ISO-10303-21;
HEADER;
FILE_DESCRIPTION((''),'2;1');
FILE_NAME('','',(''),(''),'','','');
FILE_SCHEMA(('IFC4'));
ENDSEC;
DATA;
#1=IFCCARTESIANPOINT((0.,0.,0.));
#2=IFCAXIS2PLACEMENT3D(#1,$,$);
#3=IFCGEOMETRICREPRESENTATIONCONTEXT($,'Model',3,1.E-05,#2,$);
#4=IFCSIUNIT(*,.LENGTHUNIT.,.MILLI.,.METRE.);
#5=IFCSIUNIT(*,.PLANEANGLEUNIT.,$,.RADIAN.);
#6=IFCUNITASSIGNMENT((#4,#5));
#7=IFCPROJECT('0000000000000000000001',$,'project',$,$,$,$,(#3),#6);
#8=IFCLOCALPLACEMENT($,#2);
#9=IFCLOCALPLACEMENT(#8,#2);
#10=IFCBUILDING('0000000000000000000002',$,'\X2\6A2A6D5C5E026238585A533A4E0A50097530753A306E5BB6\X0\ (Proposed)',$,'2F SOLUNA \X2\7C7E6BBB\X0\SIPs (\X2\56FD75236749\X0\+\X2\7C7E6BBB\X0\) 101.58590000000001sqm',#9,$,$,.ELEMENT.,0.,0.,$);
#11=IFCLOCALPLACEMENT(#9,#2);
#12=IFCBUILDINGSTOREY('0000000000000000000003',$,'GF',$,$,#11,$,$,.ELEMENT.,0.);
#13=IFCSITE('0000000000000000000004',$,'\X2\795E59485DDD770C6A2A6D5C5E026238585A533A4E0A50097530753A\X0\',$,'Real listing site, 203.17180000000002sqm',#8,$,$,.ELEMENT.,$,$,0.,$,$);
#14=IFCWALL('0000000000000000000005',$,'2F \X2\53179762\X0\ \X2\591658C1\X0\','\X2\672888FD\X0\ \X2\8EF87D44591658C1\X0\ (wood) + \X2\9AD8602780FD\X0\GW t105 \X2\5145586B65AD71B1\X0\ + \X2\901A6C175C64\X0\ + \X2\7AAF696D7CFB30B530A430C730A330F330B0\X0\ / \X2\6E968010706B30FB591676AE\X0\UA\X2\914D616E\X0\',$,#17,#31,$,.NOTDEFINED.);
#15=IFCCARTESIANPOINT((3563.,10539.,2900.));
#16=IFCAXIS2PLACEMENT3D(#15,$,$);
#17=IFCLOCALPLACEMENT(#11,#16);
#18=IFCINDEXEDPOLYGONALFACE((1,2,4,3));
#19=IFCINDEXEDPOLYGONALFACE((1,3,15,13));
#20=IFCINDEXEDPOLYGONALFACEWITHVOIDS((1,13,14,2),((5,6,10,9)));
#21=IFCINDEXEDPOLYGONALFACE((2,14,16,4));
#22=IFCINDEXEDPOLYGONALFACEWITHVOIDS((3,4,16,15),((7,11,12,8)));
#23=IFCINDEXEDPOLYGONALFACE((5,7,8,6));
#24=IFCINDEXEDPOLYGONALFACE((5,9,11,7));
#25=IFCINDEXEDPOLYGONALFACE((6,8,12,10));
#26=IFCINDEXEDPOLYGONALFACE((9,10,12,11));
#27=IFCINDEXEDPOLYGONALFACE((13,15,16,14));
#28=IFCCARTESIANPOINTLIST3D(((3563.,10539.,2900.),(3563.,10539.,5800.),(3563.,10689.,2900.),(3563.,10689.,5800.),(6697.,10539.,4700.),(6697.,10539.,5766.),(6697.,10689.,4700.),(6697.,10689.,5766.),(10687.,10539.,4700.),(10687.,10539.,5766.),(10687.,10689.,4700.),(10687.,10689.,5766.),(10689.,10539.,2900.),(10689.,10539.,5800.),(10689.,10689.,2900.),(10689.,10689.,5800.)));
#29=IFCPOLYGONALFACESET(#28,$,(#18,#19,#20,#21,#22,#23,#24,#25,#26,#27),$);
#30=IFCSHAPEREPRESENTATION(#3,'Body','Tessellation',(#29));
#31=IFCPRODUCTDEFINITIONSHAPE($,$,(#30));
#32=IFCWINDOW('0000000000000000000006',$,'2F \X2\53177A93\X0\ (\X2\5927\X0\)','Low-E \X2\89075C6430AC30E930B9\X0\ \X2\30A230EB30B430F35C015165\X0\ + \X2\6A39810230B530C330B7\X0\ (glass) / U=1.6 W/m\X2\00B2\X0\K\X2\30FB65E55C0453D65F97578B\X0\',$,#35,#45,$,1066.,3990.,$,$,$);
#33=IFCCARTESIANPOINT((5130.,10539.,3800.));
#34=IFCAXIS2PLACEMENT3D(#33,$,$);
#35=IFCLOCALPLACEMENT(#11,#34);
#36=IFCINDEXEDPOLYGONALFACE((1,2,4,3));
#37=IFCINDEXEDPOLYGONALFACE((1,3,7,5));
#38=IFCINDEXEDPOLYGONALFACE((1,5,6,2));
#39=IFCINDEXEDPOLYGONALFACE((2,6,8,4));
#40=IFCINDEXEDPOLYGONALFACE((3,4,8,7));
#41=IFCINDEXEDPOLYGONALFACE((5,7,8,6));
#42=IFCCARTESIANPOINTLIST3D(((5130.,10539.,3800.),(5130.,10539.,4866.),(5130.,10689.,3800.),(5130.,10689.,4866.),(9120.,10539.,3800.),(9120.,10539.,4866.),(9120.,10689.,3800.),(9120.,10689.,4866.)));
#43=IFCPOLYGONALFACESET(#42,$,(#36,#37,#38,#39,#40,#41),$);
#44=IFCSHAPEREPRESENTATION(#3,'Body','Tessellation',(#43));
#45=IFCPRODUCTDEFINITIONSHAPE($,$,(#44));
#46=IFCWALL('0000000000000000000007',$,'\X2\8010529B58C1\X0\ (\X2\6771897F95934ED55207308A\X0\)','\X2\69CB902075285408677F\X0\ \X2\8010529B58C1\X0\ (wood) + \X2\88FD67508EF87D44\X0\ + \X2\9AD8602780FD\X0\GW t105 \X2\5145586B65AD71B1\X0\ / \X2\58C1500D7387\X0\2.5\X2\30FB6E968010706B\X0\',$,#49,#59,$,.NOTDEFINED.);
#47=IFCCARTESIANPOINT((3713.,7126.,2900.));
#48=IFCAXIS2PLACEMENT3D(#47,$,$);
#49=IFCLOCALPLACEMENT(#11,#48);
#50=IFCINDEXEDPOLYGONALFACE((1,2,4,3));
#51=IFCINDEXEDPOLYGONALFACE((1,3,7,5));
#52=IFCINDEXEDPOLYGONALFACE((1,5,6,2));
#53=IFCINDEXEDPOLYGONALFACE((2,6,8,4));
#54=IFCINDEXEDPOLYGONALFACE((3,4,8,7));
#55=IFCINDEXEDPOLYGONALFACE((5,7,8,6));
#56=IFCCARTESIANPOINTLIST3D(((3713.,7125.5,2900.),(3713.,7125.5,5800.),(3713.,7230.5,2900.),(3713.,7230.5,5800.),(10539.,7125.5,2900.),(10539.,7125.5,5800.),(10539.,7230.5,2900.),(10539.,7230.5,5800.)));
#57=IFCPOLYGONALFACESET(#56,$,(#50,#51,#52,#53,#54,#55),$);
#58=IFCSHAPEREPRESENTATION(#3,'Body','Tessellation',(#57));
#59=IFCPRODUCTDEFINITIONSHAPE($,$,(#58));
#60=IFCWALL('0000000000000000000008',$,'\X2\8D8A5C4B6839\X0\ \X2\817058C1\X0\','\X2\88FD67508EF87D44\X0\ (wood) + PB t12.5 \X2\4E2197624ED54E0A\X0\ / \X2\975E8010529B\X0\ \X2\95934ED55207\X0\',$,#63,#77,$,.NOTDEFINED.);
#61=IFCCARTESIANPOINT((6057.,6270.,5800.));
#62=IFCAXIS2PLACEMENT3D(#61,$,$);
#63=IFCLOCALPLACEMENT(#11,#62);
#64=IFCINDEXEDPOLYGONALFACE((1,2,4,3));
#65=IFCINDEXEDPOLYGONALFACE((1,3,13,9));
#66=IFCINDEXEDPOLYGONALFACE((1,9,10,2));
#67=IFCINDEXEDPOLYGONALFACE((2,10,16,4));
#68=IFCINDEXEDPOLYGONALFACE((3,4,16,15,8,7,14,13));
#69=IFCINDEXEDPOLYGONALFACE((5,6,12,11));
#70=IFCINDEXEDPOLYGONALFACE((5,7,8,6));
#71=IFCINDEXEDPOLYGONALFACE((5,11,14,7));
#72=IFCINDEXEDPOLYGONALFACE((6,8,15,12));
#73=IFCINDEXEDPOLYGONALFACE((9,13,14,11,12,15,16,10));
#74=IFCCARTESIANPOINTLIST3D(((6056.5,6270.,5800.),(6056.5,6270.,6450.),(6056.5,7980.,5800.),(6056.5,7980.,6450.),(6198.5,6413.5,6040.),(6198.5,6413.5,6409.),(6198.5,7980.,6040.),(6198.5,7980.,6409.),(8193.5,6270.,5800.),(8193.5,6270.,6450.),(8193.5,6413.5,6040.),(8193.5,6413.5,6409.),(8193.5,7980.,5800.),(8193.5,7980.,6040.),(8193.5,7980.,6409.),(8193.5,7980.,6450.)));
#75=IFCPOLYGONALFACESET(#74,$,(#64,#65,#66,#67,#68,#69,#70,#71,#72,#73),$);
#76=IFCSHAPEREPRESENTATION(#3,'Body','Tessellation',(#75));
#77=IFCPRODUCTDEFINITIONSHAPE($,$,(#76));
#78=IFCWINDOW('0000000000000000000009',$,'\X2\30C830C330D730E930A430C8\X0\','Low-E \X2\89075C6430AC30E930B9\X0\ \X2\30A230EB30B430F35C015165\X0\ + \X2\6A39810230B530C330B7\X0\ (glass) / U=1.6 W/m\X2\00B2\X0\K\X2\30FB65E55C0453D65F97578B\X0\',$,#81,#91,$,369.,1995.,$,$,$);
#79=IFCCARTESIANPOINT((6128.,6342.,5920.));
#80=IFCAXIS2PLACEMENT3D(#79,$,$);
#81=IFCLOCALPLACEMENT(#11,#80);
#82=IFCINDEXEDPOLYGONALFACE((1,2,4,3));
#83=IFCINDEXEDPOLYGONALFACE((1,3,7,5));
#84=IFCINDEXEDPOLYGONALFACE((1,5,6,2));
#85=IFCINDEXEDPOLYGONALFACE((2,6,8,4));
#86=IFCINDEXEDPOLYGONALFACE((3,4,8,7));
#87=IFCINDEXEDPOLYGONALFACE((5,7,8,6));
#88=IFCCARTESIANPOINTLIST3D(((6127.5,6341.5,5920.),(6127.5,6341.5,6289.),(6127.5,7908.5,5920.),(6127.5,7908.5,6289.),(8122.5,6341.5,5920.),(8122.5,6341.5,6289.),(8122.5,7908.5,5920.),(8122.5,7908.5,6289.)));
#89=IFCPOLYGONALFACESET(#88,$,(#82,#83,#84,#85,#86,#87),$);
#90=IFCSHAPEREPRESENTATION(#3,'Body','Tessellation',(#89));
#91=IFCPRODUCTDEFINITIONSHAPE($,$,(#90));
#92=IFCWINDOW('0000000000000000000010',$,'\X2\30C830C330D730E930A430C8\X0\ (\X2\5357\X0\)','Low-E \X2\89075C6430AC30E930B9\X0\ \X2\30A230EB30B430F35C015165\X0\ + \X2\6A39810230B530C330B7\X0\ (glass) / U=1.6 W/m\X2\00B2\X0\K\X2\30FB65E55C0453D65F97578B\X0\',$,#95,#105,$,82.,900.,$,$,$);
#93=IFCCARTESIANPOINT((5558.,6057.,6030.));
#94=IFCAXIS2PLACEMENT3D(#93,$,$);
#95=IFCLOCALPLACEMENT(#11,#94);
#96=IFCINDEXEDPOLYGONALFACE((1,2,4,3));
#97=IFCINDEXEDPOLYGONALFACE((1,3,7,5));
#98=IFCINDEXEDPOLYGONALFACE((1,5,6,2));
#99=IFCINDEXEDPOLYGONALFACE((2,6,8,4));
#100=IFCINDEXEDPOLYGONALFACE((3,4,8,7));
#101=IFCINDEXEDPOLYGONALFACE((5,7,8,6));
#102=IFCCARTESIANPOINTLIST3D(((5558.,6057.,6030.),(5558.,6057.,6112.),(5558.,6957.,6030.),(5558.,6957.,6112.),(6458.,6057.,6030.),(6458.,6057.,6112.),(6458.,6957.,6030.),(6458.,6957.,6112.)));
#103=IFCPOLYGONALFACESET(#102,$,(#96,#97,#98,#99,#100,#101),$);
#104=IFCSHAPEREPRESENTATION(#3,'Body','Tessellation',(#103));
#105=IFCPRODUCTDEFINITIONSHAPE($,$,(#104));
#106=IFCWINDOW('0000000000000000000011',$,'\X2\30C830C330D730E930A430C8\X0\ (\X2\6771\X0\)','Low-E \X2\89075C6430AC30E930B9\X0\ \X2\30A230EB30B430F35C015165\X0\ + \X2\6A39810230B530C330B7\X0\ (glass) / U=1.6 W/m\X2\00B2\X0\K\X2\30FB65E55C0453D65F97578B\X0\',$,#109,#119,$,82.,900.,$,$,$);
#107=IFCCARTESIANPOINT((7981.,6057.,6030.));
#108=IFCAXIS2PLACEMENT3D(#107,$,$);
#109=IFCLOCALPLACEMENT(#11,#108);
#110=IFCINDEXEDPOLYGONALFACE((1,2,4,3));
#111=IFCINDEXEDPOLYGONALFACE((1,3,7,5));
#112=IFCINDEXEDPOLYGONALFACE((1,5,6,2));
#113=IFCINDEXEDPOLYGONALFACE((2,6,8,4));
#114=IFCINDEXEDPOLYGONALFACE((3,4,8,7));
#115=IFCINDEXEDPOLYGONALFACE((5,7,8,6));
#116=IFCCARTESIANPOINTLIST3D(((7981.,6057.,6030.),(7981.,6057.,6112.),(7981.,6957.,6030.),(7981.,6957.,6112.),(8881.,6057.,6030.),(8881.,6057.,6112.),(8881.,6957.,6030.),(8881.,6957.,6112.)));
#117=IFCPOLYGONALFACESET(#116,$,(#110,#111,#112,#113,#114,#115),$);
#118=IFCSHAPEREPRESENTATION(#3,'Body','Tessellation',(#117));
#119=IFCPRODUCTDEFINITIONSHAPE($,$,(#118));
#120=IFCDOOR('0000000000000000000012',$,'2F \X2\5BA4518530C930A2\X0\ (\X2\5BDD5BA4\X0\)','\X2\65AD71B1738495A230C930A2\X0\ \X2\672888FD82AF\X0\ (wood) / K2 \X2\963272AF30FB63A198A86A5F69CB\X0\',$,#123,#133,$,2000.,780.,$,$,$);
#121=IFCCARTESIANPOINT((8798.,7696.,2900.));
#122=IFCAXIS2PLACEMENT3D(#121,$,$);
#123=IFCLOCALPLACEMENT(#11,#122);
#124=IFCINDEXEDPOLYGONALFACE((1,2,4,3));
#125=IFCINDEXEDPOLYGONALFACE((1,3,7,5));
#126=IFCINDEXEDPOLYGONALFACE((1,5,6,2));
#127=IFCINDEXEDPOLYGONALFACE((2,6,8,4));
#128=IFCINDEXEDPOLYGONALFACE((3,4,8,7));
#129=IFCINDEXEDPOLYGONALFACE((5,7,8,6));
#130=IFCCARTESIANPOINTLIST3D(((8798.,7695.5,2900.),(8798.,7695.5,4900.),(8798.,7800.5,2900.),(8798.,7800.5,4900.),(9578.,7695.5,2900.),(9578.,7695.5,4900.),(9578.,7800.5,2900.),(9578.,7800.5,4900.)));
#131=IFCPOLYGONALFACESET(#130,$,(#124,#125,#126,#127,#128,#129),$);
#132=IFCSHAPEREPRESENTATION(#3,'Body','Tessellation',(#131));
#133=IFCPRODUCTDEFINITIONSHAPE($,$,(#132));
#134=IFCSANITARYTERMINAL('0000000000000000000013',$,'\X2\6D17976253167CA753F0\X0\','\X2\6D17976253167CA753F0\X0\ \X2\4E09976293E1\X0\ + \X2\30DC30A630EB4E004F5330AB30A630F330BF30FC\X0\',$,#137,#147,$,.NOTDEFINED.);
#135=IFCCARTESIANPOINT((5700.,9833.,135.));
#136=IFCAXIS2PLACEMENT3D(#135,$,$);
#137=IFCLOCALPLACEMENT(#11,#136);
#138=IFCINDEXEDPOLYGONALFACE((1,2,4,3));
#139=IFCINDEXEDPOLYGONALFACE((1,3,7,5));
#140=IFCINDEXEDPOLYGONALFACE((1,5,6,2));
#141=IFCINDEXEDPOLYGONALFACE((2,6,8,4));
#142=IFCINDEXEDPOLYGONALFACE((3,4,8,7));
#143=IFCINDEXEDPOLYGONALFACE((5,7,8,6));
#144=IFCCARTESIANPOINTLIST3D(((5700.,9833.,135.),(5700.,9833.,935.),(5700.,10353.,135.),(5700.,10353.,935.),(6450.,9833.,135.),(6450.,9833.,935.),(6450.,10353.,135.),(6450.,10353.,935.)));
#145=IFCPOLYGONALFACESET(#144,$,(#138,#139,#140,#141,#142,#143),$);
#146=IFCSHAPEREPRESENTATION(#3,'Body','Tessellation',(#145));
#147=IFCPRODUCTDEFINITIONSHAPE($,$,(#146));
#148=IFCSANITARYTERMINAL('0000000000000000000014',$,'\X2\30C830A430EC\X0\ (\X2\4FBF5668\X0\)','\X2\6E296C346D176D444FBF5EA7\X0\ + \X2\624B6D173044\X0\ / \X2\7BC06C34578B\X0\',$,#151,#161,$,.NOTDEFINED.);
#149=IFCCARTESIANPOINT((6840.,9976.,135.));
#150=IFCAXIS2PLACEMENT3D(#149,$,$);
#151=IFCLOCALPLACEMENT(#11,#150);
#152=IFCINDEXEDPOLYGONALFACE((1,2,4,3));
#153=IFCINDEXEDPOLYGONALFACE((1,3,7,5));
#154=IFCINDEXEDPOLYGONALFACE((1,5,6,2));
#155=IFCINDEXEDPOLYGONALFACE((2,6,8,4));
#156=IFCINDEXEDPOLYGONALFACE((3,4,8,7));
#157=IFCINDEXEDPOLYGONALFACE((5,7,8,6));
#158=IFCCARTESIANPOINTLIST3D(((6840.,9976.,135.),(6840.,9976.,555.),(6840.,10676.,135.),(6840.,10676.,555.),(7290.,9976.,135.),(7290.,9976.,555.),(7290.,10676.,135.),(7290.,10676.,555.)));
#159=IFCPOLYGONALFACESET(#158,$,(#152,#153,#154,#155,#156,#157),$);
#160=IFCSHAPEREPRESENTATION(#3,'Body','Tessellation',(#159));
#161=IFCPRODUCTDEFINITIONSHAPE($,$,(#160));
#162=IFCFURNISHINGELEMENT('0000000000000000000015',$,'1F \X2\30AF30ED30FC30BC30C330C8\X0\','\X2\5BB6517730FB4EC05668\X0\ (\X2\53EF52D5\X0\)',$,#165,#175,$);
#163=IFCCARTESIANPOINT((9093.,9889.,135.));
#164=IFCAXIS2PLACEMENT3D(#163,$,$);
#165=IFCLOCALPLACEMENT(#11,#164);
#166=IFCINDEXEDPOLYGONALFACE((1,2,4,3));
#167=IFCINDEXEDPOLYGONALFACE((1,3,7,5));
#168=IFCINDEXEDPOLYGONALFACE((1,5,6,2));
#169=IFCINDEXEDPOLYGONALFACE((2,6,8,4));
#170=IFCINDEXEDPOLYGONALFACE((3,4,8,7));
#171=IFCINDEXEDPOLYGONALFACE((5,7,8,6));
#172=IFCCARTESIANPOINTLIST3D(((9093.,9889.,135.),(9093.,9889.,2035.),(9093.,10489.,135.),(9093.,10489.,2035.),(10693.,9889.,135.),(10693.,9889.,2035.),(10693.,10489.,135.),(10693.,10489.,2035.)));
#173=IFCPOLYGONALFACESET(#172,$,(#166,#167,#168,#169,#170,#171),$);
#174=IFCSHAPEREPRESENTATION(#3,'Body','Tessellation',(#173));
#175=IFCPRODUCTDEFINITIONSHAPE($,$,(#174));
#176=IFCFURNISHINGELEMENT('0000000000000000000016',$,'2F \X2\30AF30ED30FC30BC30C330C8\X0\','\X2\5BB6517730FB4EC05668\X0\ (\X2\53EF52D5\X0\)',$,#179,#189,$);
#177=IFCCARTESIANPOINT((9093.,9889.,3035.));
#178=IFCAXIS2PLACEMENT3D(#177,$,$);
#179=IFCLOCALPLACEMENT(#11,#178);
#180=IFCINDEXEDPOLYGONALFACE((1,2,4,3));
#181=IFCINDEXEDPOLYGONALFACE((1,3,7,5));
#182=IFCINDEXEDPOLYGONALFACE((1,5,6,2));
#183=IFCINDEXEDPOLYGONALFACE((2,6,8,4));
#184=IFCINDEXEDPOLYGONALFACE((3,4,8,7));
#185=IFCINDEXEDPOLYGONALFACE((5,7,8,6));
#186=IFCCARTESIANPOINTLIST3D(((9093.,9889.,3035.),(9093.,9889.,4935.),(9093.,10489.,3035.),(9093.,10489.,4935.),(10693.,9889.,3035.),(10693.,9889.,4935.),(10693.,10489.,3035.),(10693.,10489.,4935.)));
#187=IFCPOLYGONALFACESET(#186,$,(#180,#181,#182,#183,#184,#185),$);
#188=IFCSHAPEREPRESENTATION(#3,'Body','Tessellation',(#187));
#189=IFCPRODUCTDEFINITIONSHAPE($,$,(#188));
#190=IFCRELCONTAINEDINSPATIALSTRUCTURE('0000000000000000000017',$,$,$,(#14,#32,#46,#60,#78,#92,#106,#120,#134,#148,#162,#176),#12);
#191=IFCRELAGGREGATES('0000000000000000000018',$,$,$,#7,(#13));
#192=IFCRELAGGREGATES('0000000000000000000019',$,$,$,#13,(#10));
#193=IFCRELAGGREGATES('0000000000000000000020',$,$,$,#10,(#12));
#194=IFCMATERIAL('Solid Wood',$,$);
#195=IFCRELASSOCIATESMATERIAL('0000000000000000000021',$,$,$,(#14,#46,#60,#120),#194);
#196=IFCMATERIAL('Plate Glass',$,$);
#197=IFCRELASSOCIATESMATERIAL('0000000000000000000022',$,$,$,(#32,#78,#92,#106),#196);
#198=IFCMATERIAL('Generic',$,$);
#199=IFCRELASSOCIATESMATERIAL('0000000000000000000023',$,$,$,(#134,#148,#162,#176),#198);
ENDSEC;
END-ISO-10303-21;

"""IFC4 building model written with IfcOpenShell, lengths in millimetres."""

from ifc_helpers import new_model, si_unit, frame, frame_2d, origin, place, context, project, spatial, rectangle, extrude, material, element, fill, save


model = new_model("IFC4")

# Units and contexts
model_context = context("Model", 3, precision=1e-05, world=origin())
ifc_project = project(units=[si_unit("LENGTHUNIT", "METRE", prefix="MILLI"), si_unit("PLANEANGLEUNIT", "RADIAN")], contexts=[model_context])

# Site, building, storey
site_placement = place(None, origin())
site = spatial("IfcSite", under=ifc_project, at=site_placement, Name="神奈川県横浜市戸塚区上倉田町", ObjectType="Real listing site, 203.17180000000002sqm", CompositionType="ELEMENT", RefElevation=0.0)
building_placement = place(site_placement, origin())
building = spatial("IfcBuilding", under=site, at=building_placement, Name="横浜市戸塚区上倉田町の家 (Proposed)", ObjectType="2F SOLUNA 籾殻SIPs (国産杉+籾殻) 101.58590000000001sqm", CompositionType="ELEMENT", ElevationOfRefHeight=0.0, ElevationOfTerrain=0.0)
storey_placement = place(building_placement, origin())
storey = spatial("IfcBuildingStorey", under=building, at=storey_placement, Name="GF", CompositionType="ELEMENT", Elevation=0.0)

# Wall, opening, window
ifc_material_1 = material(Name="Solid Wood")
wall_1_placement = place(storey_placement, frame((3563.0, 10539.0, 2900.0)))
wall_1 = element("IfcWall", 1, at=wall_1_placement, inside=storey, material=ifc_material_1, Name="2F 北面 外壁", Description="木製 軸組外壁 (wood) + 高性能GW t105 充填断熱 + 通気層 + 窯業系サイディング / 準耐火・外皮UA配慮", PredefinedType="NOTDEFINED", context=model_context, shape_type="SweptSolid", body=[
    extrude(rectangle(XDim=7126.0, YDim=150.0, at=frame_2d((3563.0, 75.0))), frame((3563.0, 10539.0, 2900.0)), (0.0, 0.0, 1.0), 2900.0),
])
opening_1_placement = place(storey_placement, frame((5130.0, 10539.0, 3800.0)))
opening_1 = element("IfcOpeningElement", 2, at=opening_1_placement, cuts=wall_1, PredefinedType="NOTDEFINED", context=model_context, shape_type="SweptSolid", body=[
    extrude(rectangle(XDim=3990.0, YDim=150.0, at=frame_2d((1995.0, 75.0))), frame((5130.0, 10539.0, 3800.0)), (0.0, 0.0, 1.0), 1066.0),
])
ifc_material_2 = material(Name="Plate Glass")
window_1_placement = place(storey_placement, frame((5130.0, 10539.0, 3800.0)))
window_1 = element("IfcWindow", 3, at=window_1_placement, inside=storey, material=ifc_material_2, Name="2F 北窓 (大)", Description="Low-E 複層ガラス アルゴン封入 + 樹脂サッシ (glass) / U=1.6 W/m²K・日射取得型", OverallHeight=1066.0, OverallWidth=3990.0, context=model_context, shape_type="SweptSolid", body=[
    extrude(rectangle(XDim=3990.0, YDim=150.0, at=frame_2d((1995.0, 75.0))), frame((5130.0, 10539.0, 3800.0)), (0.0, 0.0, 1.0), 1066.0),
])
fill(opening_1, window_1)

# Wall
wall_2_placement = place(storey_placement, frame((3713.0, 7126.0, 2900.0)))
element("IfcWall", 4, at=wall_2_placement, inside=storey, material=ifc_material_1, Name="耐力壁 (東西間仕切り)", Description="構造用合板 耐力壁 (wood) + 製材軸組 + 高性能GW t105 充填断熱 / 壁倍率2.5・準耐火", PredefinedType="NOTDEFINED", context=model_context, shape_type="SweptSolid", body=[
    extrude(rectangle(XDim=6826.0, YDim=105.0, at=frame_2d((3413.0, 52.0))), frame((3713.0, 7126.0, 2900.0)), (0.0, 0.0, 1.0), 2900.0),
])

# Wall, openings, windows
wall_3_placement = place(storey_placement, frame((6057.0, 6270.0, 5800.0)))
wall_3 = element("IfcWall", 5, at=wall_3_placement, inside=storey, material=ifc_material_1, Name="越屋根 腰壁", Description="製材軸組 (wood) + PB t12.5 両面仕上 / 非耐力 間仕切", PredefinedType="NOTDEFINED", context=model_context, shape_type="SweptSolid", body=[
    extrude(rectangle(XDim=2137.0, YDim=1710.0, at=frame_2d((1068.0, 855.0))), frame((6057.0, 6270.0, 5800.0)), (0.0, 0.0, 1.0), 650.0),
])
opening_2_placement = place(storey_placement, frame((6128.0, 6342.0, 5920.0)))
opening_2 = element("IfcOpeningElement", 6, at=opening_2_placement, cuts=wall_3, PredefinedType="NOTDEFINED", context=model_context, shape_type="SweptSolid", body=[
    extrude(rectangle(XDim=1995.0, YDim=1567.0, at=frame_2d((997.0, 783.0))), frame((6128.0, 6342.0, 5920.0)), (0.0, 0.0, 1.0), 369.0),
])
opening_3_placement = place(storey_placement, frame((5558.0, 6057.0, 6030.0)))
opening_3 = element("IfcOpeningElement", 7, at=opening_3_placement, cuts=wall_3, PredefinedType="NOTDEFINED", context=model_context, shape_type="SweptSolid", body=[
    extrude(rectangle(XDim=900.0, YDim=900.0, at=frame_2d((450.0, 450.0))), frame((5558.0, 6057.0, 6030.0)), (0.0, 0.0, 1.0), 82.0),
])
opening_4_placement = place(storey_placement, frame((7981.0, 6057.0, 6030.0)))
opening_4 = element("IfcOpeningElement", 8, at=opening_4_placement, cuts=wall_3, PredefinedType="NOTDEFINED", context=model_context, shape_type="SweptSolid", body=[
    extrude(rectangle(XDim=900.0, YDim=900.0, at=frame_2d((450.0, 450.0))), frame((7981.0, 6057.0, 6030.0)), (0.0, 0.0, 1.0), 82.0),
])
window_2_placement = place(storey_placement, frame((6128.0, 6342.0, 5920.0)))
window_2 = element("IfcWindow", 9, at=window_2_placement, inside=storey, material=ifc_material_2, Name="トップライト", Description="Low-E 複層ガラス アルゴン封入 + 樹脂サッシ (glass) / U=1.6 W/m²K・日射取得型", OverallHeight=369.0, OverallWidth=1995.0, context=model_context, shape_type="SweptSolid", body=[
    extrude(rectangle(XDim=1995.0, YDim=1567.0, at=frame_2d((997.0, 783.0))), frame((6128.0, 6342.0, 5920.0)), (0.0, 0.0, 1.0), 369.0),
])
fill(opening_2, window_2)
window_3_placement = place(storey_placement, frame((5558.0, 6057.0, 6030.0)))
window_3 = element("IfcWindow", 10, at=window_3_placement, inside=storey, material=ifc_material_2, Name="トップライト (南)", Description="Low-E 複層ガラス アルゴン封入 + 樹脂サッシ (glass) / U=1.6 W/m²K・日射取得型", OverallHeight=82.0, OverallWidth=900.0, context=model_context, shape_type="SweptSolid", body=[
    extrude(rectangle(XDim=900.0, YDim=900.0, at=frame_2d((450.0, 450.0))), frame((5558.0, 6057.0, 6030.0)), (0.0, 0.0, 1.0), 82.0),
])
fill(opening_3, window_3)
window_4_placement = place(storey_placement, frame((7981.0, 6057.0, 6030.0)))
window_4 = element("IfcWindow", 11, at=window_4_placement, inside=storey, material=ifc_material_2, Name="トップライト (東)", Description="Low-E 複層ガラス アルゴン封入 + 樹脂サッシ (glass) / U=1.6 W/m²K・日射取得型", OverallHeight=82.0, OverallWidth=900.0, context=model_context, shape_type="SweptSolid", body=[
    extrude(rectangle(XDim=900.0, YDim=900.0, at=frame_2d((450.0, 450.0))), frame((7981.0, 6057.0, 6030.0)), (0.0, 0.0, 1.0), 82.0),
])
fill(opening_4, window_4)

# Door
door_placement = place(storey_placement, frame((8798.0, 7696.0, 2900.0)))
element("IfcDoor", 12, at=door_placement, inside=storey, material=ifc_material_1, Name="2F 室内ドア (寝室)", Description="断熱玄関ドア 木製芯 (wood) / K2 防犯・採風機構", OverallHeight=2000.0, OverallWidth=780.0, context=model_context, shape_type="SweptSolid", body=[
    extrude(rectangle(XDim=780.0, YDim=105.0, at=frame_2d((390.0, 52.0))), frame((8798.0, 7696.0, 2900.0)), (0.0, 0.0, 1.0), 2000.0),
])

# Sanitary terminals
ifc_material_3 = material(Name="Generic")
sanitary_terminal_1_placement = place(storey_placement, frame((5700.0, 9833.0, 135.0)))
element("IfcSanitaryTerminal", 13, at=sanitary_terminal_1_placement, inside=storey, material=ifc_material_3, Name="洗面化粧台", Description="洗面化粧台 三面鏡 + ボウル一体カウンター", PredefinedType="NOTDEFINED", context=model_context, shape_type="SweptSolid", body=[
    extrude(rectangle(XDim=750.0, YDim=520.0, at=frame_2d((375.0, 260.0))), frame((5700.0, 9833.0, 135.0)), (0.0, 0.0, 1.0), 800.0),
])
sanitary_terminal_2_placement = place(storey_placement, frame((6840.0, 9976.0, 135.0)))
element("IfcSanitaryTerminal", 14, at=sanitary_terminal_2_placement, inside=storey, material=ifc_material_3, Name="トイレ (便器)", Description="温水洗浄便座 + 手洗い / 節水型", PredefinedType="NOTDEFINED", context=model_context, shape_type="SweptSolid", body=[
    extrude(rectangle(XDim=450.0, YDim=700.0, at=frame_2d((225.0, 350.0))), frame((6840.0, 9976.0, 135.0)), (0.0, 0.0, 1.0), 420.0),
])

# Furnishing elements
furnishing_1_placement = place(storey_placement, frame((9093.0, 9889.0, 135.0)))
element("IfcFurnishingElement", 15, at=furnishing_1_placement, inside=storey, material=ifc_material_3, Name="1F クローゼット", Description="家具・什器 (可動)", context=model_context, shape_type="SweptSolid", body=[
    extrude(rectangle(XDim=1600.0, YDim=600.0, at=frame_2d((800.0, 300.0))), frame((9093.0, 9889.0, 135.0)), (0.0, 0.0, 1.0), 1900.0),
])
furnishing_2_placement = place(storey_placement, frame((9093.0, 9889.0, 3035.0)))
element("IfcFurnishingElement", 16, at=furnishing_2_placement, inside=storey, material=ifc_material_3, Name="2F クローゼット", Description="家具・什器 (可動)", context=model_context, shape_type="SweptSolid", body=[
    extrude(rectangle(XDim=1600.0, YDim=600.0, at=frame_2d((800.0, 300.0))), frame((9093.0, 9889.0, 3035.0)), (0.0, 0.0, 1.0), 1900.0),
])

save(model, "model.ifc")
